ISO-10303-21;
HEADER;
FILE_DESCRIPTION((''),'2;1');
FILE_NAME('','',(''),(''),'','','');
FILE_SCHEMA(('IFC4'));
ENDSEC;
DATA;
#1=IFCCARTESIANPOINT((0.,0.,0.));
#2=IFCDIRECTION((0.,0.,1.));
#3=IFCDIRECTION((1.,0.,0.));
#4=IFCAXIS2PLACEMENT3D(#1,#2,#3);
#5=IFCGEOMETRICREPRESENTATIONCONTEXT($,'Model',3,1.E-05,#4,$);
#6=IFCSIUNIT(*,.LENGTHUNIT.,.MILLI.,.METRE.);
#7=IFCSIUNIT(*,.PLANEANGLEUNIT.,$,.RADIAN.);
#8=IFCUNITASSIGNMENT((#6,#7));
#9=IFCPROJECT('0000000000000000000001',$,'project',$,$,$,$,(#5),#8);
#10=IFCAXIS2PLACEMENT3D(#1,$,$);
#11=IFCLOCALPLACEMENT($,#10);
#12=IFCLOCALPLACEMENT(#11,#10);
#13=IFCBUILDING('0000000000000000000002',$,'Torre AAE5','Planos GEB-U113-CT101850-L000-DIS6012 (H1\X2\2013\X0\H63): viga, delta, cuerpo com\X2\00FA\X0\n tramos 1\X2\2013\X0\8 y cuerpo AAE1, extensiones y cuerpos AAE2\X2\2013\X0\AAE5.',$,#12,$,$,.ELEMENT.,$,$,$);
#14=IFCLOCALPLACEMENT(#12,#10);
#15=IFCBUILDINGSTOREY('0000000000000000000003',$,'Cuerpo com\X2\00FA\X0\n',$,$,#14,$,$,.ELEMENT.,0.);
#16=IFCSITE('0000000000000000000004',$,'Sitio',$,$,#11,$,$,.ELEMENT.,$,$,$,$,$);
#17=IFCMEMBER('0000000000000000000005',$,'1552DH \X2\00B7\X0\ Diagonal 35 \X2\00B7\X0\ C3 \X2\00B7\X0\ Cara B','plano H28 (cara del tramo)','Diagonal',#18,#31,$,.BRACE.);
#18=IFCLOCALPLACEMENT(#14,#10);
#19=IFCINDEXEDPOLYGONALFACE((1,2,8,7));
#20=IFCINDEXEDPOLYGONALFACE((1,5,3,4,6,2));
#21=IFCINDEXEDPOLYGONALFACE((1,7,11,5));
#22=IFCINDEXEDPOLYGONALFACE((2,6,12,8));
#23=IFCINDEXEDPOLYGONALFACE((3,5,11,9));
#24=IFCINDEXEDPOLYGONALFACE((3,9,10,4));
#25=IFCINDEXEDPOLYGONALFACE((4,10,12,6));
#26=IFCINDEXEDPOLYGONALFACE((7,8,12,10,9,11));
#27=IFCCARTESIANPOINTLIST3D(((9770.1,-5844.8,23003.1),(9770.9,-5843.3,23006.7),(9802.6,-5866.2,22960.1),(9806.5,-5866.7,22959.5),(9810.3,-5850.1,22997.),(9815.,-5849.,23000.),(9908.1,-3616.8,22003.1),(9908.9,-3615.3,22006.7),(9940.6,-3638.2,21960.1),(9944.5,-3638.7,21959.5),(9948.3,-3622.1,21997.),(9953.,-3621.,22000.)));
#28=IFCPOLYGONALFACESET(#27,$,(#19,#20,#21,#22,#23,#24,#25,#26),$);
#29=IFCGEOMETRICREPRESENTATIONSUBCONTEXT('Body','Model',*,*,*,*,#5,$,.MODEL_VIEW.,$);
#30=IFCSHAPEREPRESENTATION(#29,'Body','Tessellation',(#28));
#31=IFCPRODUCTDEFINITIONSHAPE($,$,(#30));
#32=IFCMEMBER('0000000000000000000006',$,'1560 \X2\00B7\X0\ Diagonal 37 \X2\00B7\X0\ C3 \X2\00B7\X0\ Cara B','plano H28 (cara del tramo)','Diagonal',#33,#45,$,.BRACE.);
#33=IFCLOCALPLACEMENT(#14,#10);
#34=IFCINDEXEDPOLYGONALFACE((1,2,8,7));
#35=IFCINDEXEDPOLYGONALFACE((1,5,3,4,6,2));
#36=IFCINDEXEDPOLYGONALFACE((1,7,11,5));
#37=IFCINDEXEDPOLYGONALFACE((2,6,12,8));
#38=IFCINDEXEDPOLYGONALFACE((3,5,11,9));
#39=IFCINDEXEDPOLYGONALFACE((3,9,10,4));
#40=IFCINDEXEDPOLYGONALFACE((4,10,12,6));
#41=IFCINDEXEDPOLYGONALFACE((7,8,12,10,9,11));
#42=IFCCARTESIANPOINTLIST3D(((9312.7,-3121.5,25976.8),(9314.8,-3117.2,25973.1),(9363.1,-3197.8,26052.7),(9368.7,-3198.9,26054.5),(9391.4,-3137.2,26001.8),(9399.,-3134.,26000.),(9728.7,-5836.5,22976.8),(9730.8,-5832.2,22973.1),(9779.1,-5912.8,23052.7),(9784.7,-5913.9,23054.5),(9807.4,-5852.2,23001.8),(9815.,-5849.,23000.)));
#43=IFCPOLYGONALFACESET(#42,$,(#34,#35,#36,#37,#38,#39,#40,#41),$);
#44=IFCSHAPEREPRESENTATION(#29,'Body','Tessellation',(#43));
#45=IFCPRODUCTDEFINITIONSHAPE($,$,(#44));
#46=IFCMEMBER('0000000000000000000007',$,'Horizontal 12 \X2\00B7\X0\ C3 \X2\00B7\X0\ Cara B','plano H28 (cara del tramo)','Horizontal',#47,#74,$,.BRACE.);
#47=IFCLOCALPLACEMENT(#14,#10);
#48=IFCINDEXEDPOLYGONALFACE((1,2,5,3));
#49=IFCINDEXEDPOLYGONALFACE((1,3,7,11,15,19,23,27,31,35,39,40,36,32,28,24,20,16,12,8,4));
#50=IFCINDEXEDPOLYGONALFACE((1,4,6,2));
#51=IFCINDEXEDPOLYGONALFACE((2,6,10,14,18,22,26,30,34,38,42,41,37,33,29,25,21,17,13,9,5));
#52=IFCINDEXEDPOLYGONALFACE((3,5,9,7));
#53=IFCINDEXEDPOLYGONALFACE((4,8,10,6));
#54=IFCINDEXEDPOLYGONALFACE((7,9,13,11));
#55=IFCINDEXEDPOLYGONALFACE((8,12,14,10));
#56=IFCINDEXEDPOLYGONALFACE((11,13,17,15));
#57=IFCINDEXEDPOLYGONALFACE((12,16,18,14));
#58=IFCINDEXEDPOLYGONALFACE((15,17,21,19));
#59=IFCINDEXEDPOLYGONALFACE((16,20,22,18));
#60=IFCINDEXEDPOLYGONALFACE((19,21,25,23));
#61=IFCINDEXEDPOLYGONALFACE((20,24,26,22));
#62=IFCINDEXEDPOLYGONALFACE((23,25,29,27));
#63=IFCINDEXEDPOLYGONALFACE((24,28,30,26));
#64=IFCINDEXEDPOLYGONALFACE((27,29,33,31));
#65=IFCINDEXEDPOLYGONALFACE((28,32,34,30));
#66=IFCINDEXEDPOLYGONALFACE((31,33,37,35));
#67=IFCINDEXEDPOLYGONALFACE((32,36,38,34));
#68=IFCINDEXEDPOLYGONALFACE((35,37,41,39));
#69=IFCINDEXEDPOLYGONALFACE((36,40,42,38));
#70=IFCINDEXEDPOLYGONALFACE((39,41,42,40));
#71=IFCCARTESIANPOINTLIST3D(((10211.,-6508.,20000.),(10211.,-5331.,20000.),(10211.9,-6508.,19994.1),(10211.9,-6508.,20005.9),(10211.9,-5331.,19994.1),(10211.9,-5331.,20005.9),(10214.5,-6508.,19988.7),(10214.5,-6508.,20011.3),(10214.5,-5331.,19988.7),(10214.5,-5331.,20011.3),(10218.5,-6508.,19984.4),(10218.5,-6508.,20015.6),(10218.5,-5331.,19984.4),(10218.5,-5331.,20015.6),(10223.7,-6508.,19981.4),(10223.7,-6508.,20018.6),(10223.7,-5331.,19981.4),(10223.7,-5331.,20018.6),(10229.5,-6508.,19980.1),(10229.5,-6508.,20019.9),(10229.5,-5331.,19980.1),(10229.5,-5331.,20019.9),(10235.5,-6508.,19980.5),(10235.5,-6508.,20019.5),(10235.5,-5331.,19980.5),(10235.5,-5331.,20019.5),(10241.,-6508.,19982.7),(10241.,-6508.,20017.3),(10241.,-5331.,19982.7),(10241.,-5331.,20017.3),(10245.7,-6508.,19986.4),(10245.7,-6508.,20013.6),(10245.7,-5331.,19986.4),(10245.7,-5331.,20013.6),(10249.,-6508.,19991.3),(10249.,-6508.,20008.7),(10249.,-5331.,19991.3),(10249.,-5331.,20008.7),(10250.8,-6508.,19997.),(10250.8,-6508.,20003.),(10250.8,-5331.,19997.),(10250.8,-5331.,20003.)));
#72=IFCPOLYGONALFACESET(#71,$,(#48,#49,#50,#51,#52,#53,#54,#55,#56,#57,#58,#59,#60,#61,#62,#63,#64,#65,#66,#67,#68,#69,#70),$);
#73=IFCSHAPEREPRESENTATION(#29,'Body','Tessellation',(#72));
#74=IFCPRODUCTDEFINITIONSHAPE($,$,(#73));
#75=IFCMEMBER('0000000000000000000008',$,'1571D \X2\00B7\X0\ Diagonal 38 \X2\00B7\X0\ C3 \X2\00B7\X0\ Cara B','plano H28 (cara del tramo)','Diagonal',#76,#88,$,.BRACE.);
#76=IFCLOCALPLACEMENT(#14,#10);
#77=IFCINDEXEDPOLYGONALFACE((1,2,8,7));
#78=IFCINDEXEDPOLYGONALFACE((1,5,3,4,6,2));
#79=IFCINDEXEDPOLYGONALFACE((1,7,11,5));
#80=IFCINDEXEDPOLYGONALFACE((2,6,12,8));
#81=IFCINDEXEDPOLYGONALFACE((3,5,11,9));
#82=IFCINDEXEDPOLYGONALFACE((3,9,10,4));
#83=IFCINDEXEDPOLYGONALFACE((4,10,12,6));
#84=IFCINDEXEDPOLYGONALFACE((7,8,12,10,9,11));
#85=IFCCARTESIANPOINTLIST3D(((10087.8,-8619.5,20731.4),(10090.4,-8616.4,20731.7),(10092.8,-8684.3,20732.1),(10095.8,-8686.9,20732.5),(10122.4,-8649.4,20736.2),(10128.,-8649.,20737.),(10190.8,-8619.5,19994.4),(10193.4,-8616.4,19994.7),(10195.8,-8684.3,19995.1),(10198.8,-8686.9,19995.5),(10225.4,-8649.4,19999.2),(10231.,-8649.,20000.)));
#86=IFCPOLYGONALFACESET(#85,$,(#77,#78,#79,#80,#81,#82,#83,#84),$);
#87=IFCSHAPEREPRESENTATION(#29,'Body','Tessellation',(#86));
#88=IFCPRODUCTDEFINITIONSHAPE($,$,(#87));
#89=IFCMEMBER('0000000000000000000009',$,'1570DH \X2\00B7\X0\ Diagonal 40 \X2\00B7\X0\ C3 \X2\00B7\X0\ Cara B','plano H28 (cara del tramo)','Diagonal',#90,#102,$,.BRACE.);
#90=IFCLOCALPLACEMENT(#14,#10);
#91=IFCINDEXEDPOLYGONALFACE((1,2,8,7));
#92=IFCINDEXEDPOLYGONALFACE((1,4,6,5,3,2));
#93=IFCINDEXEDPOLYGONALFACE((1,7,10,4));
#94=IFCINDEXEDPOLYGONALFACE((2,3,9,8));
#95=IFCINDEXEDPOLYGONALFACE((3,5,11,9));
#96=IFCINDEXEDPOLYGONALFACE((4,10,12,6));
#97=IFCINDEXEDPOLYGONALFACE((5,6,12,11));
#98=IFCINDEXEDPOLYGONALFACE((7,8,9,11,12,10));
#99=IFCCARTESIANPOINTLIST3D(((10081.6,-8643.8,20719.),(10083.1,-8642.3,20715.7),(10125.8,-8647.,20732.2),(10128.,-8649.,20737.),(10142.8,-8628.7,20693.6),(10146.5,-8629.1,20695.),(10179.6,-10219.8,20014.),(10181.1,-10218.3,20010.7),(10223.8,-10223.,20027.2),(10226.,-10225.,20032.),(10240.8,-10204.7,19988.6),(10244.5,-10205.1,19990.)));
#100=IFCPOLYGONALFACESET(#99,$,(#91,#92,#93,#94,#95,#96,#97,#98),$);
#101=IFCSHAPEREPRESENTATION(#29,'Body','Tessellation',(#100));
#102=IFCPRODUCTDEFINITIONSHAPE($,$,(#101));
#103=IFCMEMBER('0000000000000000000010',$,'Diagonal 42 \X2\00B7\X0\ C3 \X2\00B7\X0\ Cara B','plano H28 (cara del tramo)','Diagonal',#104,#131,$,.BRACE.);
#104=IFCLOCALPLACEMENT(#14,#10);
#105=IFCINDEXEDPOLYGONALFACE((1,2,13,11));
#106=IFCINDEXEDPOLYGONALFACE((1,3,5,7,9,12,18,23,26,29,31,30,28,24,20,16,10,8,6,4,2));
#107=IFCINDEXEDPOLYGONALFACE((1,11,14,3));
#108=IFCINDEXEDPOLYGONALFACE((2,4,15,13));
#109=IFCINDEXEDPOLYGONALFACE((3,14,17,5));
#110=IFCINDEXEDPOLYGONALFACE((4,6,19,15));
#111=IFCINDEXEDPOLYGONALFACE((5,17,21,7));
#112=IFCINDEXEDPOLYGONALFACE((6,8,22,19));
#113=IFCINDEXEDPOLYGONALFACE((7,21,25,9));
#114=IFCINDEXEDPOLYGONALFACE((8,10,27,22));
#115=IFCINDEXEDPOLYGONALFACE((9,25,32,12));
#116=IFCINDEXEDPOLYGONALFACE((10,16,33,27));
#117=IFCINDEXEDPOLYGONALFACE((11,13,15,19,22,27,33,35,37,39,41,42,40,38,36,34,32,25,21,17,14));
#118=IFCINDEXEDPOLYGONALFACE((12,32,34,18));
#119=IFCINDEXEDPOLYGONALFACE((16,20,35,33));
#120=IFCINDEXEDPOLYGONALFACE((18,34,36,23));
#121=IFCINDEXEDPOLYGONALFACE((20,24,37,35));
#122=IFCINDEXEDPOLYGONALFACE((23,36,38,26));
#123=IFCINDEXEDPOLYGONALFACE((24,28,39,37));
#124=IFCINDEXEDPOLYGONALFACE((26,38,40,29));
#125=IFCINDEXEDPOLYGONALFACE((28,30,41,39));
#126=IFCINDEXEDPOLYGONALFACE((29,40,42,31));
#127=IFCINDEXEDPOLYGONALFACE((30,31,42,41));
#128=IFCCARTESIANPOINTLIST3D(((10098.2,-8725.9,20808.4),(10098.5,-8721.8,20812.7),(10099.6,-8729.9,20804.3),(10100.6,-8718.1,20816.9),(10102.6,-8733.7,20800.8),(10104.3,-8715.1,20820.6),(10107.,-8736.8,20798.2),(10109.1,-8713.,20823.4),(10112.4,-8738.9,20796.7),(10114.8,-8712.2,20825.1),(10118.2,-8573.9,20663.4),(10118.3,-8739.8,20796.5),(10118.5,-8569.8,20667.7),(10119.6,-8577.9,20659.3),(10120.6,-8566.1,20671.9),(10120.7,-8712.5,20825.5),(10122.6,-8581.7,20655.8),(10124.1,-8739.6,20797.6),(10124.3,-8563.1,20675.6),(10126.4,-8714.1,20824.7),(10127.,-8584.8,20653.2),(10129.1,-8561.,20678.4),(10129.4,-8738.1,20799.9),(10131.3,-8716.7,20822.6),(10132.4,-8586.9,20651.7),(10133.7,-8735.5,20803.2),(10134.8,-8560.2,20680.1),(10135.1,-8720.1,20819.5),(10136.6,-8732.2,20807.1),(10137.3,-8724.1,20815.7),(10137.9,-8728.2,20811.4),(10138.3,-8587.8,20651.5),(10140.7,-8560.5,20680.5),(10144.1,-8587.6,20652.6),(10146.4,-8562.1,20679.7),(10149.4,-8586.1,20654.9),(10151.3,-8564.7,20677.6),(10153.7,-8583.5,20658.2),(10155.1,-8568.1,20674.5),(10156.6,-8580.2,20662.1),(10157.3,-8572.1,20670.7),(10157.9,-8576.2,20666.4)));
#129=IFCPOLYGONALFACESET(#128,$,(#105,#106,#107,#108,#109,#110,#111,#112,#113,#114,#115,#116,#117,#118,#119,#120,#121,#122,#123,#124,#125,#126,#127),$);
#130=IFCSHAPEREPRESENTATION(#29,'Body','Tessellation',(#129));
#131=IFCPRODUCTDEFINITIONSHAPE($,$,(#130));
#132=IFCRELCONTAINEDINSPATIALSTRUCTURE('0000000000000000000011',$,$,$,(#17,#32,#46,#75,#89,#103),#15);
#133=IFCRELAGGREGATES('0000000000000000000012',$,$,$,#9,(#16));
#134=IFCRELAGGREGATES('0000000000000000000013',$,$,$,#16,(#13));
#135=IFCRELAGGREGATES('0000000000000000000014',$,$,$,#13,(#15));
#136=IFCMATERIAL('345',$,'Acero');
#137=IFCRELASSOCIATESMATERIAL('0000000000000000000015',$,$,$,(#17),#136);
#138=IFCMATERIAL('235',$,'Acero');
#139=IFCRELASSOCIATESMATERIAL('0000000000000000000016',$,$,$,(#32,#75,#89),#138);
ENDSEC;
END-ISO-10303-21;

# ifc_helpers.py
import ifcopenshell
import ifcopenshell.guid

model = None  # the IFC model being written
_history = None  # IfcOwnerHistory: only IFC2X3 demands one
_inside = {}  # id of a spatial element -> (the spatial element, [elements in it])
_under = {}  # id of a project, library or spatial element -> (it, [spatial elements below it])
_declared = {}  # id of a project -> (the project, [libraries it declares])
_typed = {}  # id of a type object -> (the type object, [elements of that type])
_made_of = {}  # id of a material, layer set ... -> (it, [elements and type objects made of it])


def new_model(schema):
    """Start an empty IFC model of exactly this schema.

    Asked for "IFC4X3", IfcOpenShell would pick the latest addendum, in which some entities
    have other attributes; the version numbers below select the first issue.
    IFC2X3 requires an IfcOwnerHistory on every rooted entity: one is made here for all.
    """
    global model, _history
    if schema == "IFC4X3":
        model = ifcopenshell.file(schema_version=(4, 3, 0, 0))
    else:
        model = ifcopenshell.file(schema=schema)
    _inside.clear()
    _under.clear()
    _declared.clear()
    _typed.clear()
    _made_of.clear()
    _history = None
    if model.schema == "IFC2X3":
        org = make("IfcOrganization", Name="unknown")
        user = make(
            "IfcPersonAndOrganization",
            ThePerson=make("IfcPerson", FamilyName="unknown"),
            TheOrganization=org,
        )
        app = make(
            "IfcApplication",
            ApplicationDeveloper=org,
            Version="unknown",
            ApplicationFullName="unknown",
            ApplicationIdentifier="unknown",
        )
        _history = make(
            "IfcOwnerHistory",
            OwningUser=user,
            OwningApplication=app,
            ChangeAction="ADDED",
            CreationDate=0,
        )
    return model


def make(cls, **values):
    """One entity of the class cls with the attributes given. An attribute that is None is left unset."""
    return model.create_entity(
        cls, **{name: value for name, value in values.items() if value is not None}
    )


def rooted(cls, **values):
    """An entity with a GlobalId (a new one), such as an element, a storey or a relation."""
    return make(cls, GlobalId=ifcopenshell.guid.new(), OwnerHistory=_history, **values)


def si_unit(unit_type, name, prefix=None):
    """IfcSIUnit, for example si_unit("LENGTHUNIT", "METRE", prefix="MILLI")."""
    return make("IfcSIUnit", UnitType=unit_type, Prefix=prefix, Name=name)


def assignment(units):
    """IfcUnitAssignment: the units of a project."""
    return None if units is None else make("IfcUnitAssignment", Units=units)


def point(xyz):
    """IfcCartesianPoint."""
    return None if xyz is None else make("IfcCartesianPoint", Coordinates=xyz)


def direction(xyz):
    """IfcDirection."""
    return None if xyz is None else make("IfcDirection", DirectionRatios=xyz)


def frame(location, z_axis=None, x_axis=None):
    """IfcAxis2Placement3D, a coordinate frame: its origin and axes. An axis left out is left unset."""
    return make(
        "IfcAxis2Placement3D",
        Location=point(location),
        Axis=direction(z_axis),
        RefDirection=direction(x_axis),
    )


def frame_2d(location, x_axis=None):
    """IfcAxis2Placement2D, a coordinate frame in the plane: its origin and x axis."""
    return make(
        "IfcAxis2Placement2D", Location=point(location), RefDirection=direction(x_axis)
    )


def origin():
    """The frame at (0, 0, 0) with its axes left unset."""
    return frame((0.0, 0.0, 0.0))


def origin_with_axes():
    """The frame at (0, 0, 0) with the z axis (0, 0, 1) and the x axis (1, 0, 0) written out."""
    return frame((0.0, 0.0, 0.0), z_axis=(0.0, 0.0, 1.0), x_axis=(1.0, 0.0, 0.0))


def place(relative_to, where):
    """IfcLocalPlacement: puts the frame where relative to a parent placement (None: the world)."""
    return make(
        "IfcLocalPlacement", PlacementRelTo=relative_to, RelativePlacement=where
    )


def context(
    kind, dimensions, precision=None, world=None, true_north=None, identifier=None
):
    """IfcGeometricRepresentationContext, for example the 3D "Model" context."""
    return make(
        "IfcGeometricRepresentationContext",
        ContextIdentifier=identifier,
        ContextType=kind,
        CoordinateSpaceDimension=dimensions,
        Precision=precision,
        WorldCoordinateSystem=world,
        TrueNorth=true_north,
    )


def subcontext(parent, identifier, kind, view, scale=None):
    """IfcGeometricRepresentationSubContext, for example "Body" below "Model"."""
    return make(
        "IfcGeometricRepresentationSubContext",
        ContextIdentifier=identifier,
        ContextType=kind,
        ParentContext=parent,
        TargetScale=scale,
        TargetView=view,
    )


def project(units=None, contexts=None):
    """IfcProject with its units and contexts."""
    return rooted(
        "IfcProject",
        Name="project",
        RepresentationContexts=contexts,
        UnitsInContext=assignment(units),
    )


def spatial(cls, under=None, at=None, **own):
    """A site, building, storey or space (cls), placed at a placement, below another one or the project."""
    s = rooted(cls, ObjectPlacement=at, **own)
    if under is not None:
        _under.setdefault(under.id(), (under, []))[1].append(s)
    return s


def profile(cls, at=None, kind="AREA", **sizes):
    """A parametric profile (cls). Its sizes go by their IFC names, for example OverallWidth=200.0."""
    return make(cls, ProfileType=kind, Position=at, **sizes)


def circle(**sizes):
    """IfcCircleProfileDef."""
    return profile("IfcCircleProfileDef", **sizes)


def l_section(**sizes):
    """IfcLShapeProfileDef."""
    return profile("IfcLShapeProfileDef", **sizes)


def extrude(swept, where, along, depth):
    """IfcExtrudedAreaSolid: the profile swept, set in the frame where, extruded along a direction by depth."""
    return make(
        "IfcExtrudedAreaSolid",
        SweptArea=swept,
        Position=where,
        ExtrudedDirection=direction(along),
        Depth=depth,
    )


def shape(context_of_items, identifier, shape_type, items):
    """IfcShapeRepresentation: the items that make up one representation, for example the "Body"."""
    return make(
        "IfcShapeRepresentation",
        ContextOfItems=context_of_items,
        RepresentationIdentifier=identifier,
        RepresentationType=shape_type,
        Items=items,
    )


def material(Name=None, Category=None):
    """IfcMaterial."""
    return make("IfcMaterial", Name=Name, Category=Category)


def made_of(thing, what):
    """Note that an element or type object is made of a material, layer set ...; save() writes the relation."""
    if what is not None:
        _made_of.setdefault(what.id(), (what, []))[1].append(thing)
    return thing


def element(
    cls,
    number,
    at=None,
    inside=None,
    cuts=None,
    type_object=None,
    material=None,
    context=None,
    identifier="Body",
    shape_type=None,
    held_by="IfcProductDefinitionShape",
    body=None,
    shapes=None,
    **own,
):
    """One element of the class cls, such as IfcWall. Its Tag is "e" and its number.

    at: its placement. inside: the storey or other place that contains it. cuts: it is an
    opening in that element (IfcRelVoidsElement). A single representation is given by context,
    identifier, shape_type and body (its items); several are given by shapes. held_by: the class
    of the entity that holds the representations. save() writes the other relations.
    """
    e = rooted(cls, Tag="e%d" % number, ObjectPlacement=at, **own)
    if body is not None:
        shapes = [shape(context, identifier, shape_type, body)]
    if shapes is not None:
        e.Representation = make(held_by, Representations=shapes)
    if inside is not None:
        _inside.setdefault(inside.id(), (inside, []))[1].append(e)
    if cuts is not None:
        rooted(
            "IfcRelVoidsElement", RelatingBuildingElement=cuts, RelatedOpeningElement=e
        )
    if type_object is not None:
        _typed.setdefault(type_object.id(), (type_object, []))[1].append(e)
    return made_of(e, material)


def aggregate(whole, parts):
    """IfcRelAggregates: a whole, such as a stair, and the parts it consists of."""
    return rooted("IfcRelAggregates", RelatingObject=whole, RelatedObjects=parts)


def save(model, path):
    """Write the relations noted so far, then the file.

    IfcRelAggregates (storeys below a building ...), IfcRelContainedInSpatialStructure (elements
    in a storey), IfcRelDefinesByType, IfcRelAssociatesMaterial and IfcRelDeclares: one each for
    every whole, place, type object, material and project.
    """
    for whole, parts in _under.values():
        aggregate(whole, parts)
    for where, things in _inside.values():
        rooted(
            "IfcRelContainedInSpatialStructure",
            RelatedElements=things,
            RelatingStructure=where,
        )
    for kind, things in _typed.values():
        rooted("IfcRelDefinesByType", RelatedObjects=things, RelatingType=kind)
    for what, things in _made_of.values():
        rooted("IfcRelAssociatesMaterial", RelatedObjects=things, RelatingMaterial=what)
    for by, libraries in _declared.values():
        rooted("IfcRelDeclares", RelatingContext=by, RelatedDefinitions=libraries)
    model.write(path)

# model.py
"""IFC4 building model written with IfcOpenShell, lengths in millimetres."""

from ifc_helpers import new_model, si_unit, frame, frame_2d, origin, origin_with_axes, place, context, subcontext, project, spatial, circle, l_section, extrude, material, element, save


model = new_model("IFC4")

# Units and contexts
model_context = context("Model", 3, precision=1e-05, world=origin_with_axes())
body_context = subcontext(model_context, "Body", "Model", "MODEL_VIEW")
ifc_project = project(units=[si_unit("LENGTHUNIT", "METRE", prefix="MILLI"), si_unit("PLANEANGLEUNIT", "RADIAN")], contexts=[model_context])

# Site, building, storey
site_placement = place(None, origin())
site = spatial("IfcSite", under=ifc_project, at=site_placement, Name="Sitio", CompositionType="ELEMENT")
building_placement = place(site_placement, origin())
building = spatial("IfcBuilding", under=site, at=building_placement, Name="Torre AAE5", Description="Planos GEB-U113-CT101850-L000-DIS6012 (H1–H63): viga, delta, cuerpo común tramos 1–8 y cuerpo AAE1, extensiones y cuerpos AAE2–AAE5.", CompositionType="ELEMENT")
storey_placement = place(building_placement, origin())
storey = spatial("IfcBuildingStorey", under=building, at=storey_placement, Name="Cuerpo común", CompositionType="ELEMENT", Elevation=0.0)

# Members
ifc_material_1 = material(Name="235", Category="Acero")
ifc_material_2 = material(Name="345", Category="Acero")
member_1_placement = place(storey_placement, frame((9953.0, -3621.0, 22000.0), z_axis=(-0.056418, -0.910866, 0.408827), x_axis=(-0.980545, 0.12766, 0.149111)))
element("IfcMember", 1, at=member_1_placement, inside=storey, material=ifc_material_2, Name="1552DH · Diagonal 35 · C3 · Cara B", Description="plano H28 (cara del tramo)", ObjectType="Diagonal", PredefinedType="BRACE", context=body_context, shape_type="SweptSolid", body=[
    extrude(l_section(Depth=45.0, Width=45.0, Thickness=4.0, at=frame_2d((22.5, 22.5))), None, (0.0, 0.0, 1.0), 2446.0),
])
member_2_placement = place(storey_placement, frame((9815.0, -5849.0, 23000.0), z_axis=(-0.102275, 0.667492, 0.73756), x_axis=(-0.935928, 0.186627, -0.298679)))
element("IfcMember", 2, at=member_2_placement, inside=storey, material=ifc_material_1, Name="1560 · Diagonal 37 · C3 · Cara B", Description="plano H28 (cara del tramo)", ObjectType="Diagonal", PredefinedType="BRACE", context=body_context, shape_type="SweptSolid", body=[
    extrude(l_section(Depth=90.0, Width=90.0, Thickness=6.0, at=frame_2d((45.0, 45.0))), None, (0.0, 0.0, 1.0), 4067.5),
])
member_3_placement = place(storey_placement, frame((10231.0, -6508.0, 20000.0), z_axis=(0.0, 1.0, 0.0), x_axis=(-1.0, 0.0, 0.0)))
element("IfcMember", 3, at=member_3_placement, inside=storey, Name="Horizontal 12 · C3 · Cara B", Description="plano H28 (cara del tramo)", ObjectType="Horizontal", PredefinedType="BRACE", context=body_context, shape_type="SweptSolid", body=[
    extrude(circle(Radius=20.0), None, (0.0, 0.0, 1.0), 1177.0),
])
member_4_placement = place(storey_placement, frame((10231.0, -8649.0, 20000.0), z_axis=(-0.138411, 0.0, 0.990375), x_axis=(-0.751665, 0.651125, -0.10505)))
element("IfcMember", 4, at=member_4_placement, inside=storey, material=ifc_material_1, Name="1571D · Diagonal 38 · C3 · Cara B", Description="plano H28 (cara del tramo)", ObjectType="Diagonal", PredefinedType="BRACE", context=body_context, shape_type="SweptSolid", body=[
    extrude(l_section(Depth=50.0, Width=50.0, Thickness=4.0, at=frame_2d((25.0, 25.0))), None, (0.0, 0.0, 1.0), 744.2),
])
member_5_placement = place(storey_placement, frame((10128.0, -8649.0, 20737.0), z_axis=(0.056671, -0.911363, -0.407684), x_axis=(-0.927495, 0.103073, -0.359344)))
element("IfcMember", 5, at=member_5_placement, inside=storey, material=ifc_material_1, Name="1570DH · Diagonal 40 · C3 · Cara B", Description="plano H28 (cara del tramo)", ObjectType="Diagonal", PredefinedType="BRACE", context=body_context, shape_type="SweptSolid", body=[
    extrude(l_section(Depth=50.0, Width=50.0, Thickness=4.0, at=frame_2d((25.0, 25.0))), None, (0.0, 0.0, 1.0), 1729.3),
])
member_6_placement = place(storey_placement, frame((10138.0, -8574.0, 20666.0), z_axis=(-0.094778, -0.720314, 0.687142), x_axis=(-0.868845, 0.396782, 0.296096)))
element("IfcMember", 6, at=member_6_placement, inside=storey, Name="Diagonal 42 · C3 · Cara B", Description="plano H28 (cara del tramo)", ObjectType="Diagonal", PredefinedType="BRACE", context=body_context, shape_type="SweptSolid", body=[
    extrude(circle(Radius=20.0), None, (0.0, 0.0, 1.0), 211.0),
])

save(model, "model.ifc")
